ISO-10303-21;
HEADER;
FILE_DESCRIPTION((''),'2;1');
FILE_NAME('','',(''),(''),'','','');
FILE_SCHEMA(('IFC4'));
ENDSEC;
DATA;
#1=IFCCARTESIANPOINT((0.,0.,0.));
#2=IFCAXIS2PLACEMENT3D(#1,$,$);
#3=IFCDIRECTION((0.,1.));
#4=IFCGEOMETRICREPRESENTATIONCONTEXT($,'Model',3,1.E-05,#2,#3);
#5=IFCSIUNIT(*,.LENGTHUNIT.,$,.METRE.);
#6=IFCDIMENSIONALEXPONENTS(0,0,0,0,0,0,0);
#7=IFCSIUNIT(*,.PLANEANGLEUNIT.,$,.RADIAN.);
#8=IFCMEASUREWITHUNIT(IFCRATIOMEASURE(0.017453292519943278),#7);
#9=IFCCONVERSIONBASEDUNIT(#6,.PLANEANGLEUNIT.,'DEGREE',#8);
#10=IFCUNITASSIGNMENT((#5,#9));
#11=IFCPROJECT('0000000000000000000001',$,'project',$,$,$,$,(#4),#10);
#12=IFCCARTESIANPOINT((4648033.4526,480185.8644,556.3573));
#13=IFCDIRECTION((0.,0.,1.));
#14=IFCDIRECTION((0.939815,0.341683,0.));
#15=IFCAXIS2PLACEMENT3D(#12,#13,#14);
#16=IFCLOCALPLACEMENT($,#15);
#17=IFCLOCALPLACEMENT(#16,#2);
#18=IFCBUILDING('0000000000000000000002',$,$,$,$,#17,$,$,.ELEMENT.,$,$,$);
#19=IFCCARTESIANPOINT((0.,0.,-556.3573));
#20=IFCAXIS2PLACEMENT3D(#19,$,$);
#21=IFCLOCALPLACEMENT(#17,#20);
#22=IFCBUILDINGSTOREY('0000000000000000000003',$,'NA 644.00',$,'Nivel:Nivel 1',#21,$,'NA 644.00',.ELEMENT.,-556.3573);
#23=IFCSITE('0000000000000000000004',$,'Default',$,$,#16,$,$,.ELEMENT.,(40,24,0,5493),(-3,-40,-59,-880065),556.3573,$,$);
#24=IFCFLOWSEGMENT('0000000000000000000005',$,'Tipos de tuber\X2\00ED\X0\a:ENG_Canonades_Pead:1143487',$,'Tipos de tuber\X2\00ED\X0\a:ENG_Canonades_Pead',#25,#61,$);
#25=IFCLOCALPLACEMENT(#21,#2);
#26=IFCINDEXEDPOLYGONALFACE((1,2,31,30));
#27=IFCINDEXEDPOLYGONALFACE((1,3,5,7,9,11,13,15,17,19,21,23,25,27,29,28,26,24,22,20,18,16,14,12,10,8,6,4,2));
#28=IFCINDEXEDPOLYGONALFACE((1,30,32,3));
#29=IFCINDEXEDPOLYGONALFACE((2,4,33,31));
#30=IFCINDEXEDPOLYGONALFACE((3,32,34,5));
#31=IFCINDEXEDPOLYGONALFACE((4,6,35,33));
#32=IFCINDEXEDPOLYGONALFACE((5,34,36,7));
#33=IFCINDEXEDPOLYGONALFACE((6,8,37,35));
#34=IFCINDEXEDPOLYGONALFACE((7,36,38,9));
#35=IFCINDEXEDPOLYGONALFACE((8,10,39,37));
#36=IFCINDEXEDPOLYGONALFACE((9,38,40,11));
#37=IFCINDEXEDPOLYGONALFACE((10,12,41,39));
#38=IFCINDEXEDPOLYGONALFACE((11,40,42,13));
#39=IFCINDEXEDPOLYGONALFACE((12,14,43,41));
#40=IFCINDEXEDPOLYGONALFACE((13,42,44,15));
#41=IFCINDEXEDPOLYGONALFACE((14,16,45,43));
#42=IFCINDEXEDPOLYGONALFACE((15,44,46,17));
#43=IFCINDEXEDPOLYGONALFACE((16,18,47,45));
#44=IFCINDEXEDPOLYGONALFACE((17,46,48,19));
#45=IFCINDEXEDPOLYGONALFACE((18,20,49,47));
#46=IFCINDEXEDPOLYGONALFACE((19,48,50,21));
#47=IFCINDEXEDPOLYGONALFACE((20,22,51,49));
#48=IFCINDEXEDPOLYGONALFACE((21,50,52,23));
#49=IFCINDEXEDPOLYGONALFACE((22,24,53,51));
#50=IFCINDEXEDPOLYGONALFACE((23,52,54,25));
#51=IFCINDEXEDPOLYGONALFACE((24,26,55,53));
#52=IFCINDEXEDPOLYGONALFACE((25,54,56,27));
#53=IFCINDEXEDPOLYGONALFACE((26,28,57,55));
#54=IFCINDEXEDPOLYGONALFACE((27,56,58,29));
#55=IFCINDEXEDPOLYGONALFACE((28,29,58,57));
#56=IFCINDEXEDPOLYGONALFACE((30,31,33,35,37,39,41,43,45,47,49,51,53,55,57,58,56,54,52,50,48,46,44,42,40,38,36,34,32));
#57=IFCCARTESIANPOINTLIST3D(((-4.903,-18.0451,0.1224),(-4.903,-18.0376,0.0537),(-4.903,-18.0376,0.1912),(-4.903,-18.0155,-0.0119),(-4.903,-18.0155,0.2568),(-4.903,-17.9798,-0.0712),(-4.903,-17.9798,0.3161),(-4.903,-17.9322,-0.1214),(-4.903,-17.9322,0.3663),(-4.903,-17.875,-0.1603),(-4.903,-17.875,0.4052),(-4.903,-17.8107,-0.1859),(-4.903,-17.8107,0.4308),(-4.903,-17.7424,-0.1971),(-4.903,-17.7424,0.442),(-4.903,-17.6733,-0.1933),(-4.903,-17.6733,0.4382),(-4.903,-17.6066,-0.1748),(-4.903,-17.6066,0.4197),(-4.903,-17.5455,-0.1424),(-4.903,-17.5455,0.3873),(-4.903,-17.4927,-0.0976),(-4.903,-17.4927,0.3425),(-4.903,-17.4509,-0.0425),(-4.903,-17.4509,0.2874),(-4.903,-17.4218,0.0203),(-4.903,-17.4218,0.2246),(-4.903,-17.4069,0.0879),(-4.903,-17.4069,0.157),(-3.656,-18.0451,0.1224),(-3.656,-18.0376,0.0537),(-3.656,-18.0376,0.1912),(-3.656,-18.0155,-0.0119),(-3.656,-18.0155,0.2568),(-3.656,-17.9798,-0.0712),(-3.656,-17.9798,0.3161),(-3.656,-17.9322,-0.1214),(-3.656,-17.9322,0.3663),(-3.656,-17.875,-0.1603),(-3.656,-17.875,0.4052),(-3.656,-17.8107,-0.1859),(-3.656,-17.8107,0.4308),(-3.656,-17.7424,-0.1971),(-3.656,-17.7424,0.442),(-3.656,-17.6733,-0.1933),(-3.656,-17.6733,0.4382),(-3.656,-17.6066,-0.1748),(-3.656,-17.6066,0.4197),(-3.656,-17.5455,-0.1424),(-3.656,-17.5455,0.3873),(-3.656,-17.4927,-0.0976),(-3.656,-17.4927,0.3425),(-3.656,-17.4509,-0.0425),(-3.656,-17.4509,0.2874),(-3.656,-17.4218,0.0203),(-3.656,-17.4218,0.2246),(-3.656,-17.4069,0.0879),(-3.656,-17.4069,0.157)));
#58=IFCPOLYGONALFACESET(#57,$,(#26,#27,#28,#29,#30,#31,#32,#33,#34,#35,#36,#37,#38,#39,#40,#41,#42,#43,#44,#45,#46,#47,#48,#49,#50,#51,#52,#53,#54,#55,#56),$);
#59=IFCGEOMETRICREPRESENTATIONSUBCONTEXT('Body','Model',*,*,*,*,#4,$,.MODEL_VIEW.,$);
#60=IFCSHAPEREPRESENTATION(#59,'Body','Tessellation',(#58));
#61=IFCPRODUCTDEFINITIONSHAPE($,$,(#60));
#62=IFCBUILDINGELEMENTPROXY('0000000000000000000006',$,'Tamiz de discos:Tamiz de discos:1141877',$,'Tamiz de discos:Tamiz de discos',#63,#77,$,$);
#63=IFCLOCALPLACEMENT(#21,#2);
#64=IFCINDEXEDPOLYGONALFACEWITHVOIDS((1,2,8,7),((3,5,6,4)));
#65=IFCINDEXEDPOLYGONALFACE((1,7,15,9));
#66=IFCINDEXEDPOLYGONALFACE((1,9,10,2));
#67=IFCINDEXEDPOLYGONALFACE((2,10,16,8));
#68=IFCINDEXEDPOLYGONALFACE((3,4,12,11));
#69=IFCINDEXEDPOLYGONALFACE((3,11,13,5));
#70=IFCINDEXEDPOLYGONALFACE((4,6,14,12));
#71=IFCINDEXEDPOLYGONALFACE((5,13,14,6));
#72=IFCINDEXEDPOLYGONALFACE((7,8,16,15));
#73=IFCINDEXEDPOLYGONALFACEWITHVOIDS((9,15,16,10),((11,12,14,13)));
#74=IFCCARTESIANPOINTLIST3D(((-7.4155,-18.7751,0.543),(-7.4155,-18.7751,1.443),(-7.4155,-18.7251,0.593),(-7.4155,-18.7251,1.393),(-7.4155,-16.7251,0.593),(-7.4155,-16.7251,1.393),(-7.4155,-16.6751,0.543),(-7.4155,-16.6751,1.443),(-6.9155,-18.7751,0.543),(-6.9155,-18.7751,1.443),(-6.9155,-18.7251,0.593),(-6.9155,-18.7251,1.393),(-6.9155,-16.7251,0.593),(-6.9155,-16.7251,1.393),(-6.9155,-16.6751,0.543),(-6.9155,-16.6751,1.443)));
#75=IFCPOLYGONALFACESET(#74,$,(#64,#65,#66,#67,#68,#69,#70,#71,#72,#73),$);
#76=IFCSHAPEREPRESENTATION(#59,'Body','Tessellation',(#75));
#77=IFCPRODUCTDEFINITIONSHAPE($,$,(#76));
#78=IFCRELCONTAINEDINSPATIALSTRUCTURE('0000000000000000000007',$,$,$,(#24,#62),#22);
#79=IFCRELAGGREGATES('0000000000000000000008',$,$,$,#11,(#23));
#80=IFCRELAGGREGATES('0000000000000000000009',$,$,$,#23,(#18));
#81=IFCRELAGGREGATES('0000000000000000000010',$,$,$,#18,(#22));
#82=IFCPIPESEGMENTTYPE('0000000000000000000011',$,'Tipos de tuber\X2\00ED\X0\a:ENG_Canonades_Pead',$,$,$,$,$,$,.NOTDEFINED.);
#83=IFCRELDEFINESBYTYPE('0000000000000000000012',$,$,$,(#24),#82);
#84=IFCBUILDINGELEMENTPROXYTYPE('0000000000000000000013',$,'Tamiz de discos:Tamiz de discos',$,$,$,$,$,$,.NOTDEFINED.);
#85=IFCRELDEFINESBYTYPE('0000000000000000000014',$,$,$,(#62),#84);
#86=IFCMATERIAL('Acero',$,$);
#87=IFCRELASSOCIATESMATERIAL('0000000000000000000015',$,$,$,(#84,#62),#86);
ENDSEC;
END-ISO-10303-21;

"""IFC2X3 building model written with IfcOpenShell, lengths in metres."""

from ifc_helpers import new_model, entity, si_unit, converted_unit, direction, frame, origin, origin_2d_with_axis, place, context, subcontext, project, spatial, polyline, circle, outline, extrude, source, transform, mapped, material, type_object, type_shapes, element, save


model = new_model("IFC2X3")

# Units and contexts
model_context = context("Model", 3, precision=1e-05, world=origin(), true_north=direction((0.0, 1.0)))
body_context = subcontext(model_context, "Body", "Model", "MODEL_VIEW")
ifc_project = project(units=[si_unit("LENGTHUNIT", "METRE"), converted_unit("PLANEANGLEUNIT", "DEGREE", entity("IfcRatioMeasure", 0.017453292519943278), si_unit("PLANEANGLEUNIT", "RADIAN"), dimensions=[0, 0, 0, 0, 0, 0, 0])], contexts=[model_context])

# Site, building, storey
site_placement = place(None, frame((4648033.4526, 480185.8644, 556.3573), z_axis=(0.0, 0.0, 1.0), x_axis=(0.939815, 0.341683, 0.0)))
site = spatial("IfcSite", under=ifc_project, at=site_placement, Name="Default", CompositionType="ELEMENT", RefLatitude=(40, 24, 0, 5493), RefLongitude=(-3, -40, -59, -880065), RefElevation=556.3573)
building_placement = place(site_placement, origin())
building = spatial("IfcBuilding", under=site, at=building_placement, CompositionType="ELEMENT")
storey_placement = place(building_placement, frame((0.0, 0.0, -556.3573)))
storey = spatial("IfcBuildingStorey", under=building, at=storey_placement, Name="NA 644.00", ObjectType="Nivel:Nivel 1", LongName="NA 644.00", CompositionType="ELEMENT", Elevation=-556.3573)

# Flow segment
pipe_segment_type = type_object("IfcPipeSegmentType", Name="Tipos de tubería:ENG_Canonades_Pead", PredefinedType="NOTDEFINED")
flow_segment_1_placement = place(storey_placement, origin())
element("IfcFlowSegment", 1, at=flow_segment_1_placement, inside=storey, type_object=pipe_segment_type, Name="Tipos de tubería:ENG_Canonades_Pead:1143487", ObjectType="Tipos de tubería:ENG_Canonades_Pead", context=body_context, shape_type="SweptSolid", body=[
    extrude(circle(Radius=0.32, at=origin_2d_with_axis()), frame((-4.903, -17.7251, 0.1224), z_axis=(1.0, 0.0, 0.0), x_axis=(0.0, -1.0, 0.0)), (0.0, 0.0, 1.0), 1.247),
])

# Building element proxy
ifc_material_1 = material(Name="Acero")
building_element_proxy_type_1 = type_object("IfcBuildingElementProxyType", Name="Tamiz de discos:Tamiz de discos", PredefinedType="NOTDEFINED", material=ifc_material_1)
shared_shape_1 = source(origin(), body_context, "Body", "SweptSolid", [
    extrude(outline(polyline([(-1.05, -0.45), (1.05, -0.45), (1.05, 0.45), (-1.05, 0.45), (-1.05, -0.45)]), holes=[polyline([(-1.0, -0.4), (-1.0, 0.4), (1.0, 0.4), (1.0, -0.4), (-1.0, -0.4)])]), frame((-7.4155, -17.7251, -555.3643), z_axis=(1.0, 0.0, 0.0), x_axis=(0.0, -1.0, 0.0)), (0.0, 0.0, 1.0), 0.5),
])
type_shapes(building_element_proxy_type_1, [shared_shape_1])
proxy_1_placement = place(storey_placement, frame((0.0, 0.0, 556.3573)))
element("IfcBuildingElementProxy", 2, at=proxy_1_placement, inside=storey, type_object=building_element_proxy_type_1, material=ifc_material_1, Name="Tamiz de discos:Tamiz de discos:1141877", ObjectType="Tamiz de discos:Tamiz de discos", context=body_context, shape_type="MappedRepresentation", body=[
    mapped(shared_shape_1, transform((0.0, 0.0, 0.0), scale=1.0)),
])

save(model, "model.ifc")
